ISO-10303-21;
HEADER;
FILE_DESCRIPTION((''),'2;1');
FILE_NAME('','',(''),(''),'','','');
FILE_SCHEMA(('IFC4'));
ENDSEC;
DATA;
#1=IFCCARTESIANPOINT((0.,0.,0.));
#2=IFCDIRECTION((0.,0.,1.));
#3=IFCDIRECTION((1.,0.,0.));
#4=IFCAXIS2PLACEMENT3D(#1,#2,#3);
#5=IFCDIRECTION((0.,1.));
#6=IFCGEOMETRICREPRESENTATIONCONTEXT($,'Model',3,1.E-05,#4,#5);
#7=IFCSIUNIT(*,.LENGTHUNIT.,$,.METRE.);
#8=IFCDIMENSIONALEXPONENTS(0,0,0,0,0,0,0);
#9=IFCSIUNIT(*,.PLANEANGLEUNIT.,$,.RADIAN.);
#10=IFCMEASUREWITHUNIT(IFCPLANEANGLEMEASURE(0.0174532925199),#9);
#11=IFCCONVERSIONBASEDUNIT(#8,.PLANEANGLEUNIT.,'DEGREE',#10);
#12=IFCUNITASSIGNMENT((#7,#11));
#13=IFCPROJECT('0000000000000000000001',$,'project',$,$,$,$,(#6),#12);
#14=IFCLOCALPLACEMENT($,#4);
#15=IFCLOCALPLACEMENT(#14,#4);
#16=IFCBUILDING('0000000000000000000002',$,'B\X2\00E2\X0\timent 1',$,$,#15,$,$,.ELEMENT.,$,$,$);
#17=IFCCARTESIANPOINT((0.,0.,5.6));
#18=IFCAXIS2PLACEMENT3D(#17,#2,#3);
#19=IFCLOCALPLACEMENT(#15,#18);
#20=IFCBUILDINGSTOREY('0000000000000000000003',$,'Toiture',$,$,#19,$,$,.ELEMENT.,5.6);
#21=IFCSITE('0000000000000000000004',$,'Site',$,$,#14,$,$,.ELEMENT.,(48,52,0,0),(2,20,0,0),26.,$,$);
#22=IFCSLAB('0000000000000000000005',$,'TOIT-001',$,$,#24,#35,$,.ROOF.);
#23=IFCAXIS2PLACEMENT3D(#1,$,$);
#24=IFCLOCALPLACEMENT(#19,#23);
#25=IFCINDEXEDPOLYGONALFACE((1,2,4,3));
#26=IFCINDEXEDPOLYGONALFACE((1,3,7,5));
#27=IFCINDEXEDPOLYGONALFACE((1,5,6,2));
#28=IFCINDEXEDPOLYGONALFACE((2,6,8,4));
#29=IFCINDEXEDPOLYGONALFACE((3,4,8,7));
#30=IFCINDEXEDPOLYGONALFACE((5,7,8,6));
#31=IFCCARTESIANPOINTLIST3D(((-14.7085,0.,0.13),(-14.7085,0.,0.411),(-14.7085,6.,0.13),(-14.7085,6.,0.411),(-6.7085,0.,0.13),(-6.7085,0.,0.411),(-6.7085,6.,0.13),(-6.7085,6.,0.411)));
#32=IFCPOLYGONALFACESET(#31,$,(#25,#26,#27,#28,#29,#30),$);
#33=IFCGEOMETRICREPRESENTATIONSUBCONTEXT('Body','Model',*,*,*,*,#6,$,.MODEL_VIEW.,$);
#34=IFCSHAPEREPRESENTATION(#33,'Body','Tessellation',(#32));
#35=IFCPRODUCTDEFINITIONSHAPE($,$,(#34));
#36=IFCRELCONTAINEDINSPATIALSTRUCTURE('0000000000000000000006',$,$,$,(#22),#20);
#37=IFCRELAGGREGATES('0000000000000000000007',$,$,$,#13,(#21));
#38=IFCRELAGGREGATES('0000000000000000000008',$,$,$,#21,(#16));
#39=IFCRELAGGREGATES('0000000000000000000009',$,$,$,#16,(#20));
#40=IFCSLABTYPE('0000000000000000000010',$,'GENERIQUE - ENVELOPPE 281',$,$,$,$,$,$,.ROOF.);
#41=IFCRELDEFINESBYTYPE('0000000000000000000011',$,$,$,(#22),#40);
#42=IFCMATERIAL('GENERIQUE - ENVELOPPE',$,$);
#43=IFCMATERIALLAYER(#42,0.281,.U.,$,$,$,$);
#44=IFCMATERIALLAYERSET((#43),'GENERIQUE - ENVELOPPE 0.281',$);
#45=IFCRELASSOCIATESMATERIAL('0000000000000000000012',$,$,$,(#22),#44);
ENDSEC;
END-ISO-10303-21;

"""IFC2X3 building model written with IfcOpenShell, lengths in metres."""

from ifc_helpers import new_model, entity, si_unit, converted_unit, direction, frame, origin_with_axes, place, context, subcontext, project, spatial, polyline, outline, extrude, material, layer, layer_set, layer_usage, type_object, element, save


model = new_model("IFC2X3")

# Units and contexts
model_context = context("Model", 3, precision=1e-05, world=origin_with_axes(), true_north=direction((0.0, 1.0)))
body_context = subcontext(model_context, "Body", "Model", "MODEL_VIEW")
ifc_project = project(units=[si_unit("LENGTHUNIT", "METRE"), converted_unit("PLANEANGLEUNIT", "DEGREE", entity("IfcPlaneAngleMeasure", 0.0174532925199), si_unit("PLANEANGLEUNIT", "RADIAN"), dimensions=[0, 0, 0, 0, 0, 0, 0])], contexts=[model_context])

# Site, building, storey
site_placement = place(None, origin_with_axes())
site = spatial("IfcSite", under=ifc_project, at=site_placement, Name="Site", CompositionType="ELEMENT", RefLatitude=(48, 52, 0, 0), RefLongitude=(2, 20, 0, 0), RefElevation=26.0)
building_placement = place(site_placement, origin_with_axes())
building = spatial("IfcBuilding", under=site, at=building_placement, Name="Bâtiment 1", CompositionType="ELEMENT")
storey_placement = place(building_placement, frame((0.0, 0.0, 5.6), z_axis=(0.0, 0.0, 1.0), x_axis=(1.0, 0.0, 0.0)))
storey = spatial("IfcBuildingStorey", under=building, at=storey_placement, Name="Toiture", CompositionType="ELEMENT", Elevation=5.6)

# Slab
ifc_material = material(Name="GENERIQUE - ENVELOPPE")
ifc_layer = layer(ifc_material, 0.281, ventilated="UNKNOWN")
ifc_layer_set = layer_set([ifc_layer], Name="GENERIQUE - ENVELOPPE 0.281")
ifc_layer_usage = layer_usage(ifc_layer_set, "AXIS3", "NEGATIVE", 0.281)
slab_type = type_object("IfcSlabType", Name="GENERIQUE - ENVELOPPE 281", PredefinedType="ROOF")
slab_placement = place(storey_placement, frame((-14.7085, 6.0, 0.13), z_axis=(0.0, 0.0, 1.0), x_axis=(0.0, -1.0, 0.0)))
element("IfcSlab", 1, at=slab_placement, inside=storey, type_object=slab_type, material=ifc_layer_usage, Name="TOIT-001", PredefinedType="ROOF", context=body_context, shape_type="SweptSolid", body=[
    extrude(outline(polyline([(0.0, 0.0), (6.0, 0.0), (6.0, 8.0), (0.0, 8.0), (0.0, 0.0)])), origin_with_axes(), (0.0, 0.0, 1.0), 0.281),
])

save(model, "model.ifc")
